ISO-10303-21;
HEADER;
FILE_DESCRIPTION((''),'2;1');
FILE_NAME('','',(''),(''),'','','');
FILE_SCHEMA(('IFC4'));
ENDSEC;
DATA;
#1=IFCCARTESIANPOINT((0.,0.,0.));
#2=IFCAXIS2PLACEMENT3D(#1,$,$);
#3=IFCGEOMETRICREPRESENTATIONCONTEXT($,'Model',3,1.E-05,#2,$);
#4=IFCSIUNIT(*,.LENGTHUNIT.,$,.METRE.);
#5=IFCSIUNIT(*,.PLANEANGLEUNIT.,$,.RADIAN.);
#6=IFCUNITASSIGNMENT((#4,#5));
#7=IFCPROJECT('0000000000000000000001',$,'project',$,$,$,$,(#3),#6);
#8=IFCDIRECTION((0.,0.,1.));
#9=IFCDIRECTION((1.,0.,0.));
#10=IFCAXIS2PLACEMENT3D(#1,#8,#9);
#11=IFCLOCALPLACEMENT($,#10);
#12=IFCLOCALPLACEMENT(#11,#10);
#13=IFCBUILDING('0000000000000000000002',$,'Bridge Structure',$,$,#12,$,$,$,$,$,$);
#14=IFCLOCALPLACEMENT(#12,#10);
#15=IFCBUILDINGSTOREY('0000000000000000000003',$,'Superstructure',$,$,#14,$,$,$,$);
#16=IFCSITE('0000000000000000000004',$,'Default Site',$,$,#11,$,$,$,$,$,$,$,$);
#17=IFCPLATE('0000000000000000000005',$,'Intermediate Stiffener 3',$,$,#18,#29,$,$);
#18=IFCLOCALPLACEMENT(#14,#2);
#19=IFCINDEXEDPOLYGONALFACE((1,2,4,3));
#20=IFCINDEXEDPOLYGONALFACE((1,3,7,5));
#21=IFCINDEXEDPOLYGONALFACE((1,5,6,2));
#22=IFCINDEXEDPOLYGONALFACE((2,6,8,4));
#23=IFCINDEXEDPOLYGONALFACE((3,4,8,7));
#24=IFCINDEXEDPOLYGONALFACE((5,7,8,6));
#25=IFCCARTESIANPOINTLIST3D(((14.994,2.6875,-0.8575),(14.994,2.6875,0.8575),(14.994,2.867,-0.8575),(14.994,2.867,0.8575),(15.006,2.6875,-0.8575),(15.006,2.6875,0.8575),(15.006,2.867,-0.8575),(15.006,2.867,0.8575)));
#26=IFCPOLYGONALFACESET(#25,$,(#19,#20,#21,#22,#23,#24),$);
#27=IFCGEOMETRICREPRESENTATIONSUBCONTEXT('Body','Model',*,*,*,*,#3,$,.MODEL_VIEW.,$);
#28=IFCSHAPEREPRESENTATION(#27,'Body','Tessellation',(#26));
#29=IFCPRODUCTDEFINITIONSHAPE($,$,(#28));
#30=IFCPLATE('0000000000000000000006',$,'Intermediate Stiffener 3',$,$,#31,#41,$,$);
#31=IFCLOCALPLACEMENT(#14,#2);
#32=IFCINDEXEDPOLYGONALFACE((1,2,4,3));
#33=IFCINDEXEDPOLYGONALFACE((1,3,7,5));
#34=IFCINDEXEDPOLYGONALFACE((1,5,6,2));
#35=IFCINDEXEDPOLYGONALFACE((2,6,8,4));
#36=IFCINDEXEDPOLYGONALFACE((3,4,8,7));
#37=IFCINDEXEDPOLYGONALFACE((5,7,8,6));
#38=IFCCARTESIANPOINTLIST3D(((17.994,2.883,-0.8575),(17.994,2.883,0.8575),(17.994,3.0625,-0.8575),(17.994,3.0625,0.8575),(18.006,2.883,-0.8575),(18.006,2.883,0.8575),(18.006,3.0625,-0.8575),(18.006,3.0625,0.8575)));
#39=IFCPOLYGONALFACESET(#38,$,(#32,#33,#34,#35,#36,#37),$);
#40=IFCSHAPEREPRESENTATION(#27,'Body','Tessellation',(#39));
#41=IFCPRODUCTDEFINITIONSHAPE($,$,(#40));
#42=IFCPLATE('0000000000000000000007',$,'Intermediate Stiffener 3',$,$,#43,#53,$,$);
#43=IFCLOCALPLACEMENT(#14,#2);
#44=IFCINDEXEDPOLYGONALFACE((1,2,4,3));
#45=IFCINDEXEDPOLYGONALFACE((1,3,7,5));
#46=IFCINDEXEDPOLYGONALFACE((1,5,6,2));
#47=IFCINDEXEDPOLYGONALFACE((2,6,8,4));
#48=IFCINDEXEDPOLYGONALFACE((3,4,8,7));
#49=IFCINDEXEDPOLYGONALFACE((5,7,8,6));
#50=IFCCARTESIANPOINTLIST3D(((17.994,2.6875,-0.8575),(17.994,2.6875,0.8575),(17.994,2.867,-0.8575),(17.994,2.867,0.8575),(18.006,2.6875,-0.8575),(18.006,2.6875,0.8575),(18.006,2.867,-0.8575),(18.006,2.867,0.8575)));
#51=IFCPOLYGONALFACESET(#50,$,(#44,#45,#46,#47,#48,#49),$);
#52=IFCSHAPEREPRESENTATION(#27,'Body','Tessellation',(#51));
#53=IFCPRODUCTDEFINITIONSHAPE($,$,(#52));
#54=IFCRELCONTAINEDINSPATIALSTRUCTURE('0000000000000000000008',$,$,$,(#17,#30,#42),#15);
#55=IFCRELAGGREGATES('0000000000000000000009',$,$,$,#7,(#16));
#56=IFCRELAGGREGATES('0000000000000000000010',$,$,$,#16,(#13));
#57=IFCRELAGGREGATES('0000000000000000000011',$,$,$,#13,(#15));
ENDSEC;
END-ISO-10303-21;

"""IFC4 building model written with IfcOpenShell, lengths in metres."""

from ifc_helpers import new_model, si_unit, frame, origin, origin_with_axes, origin_2d_with_axis, place, context, subcontext, project, spatial, rectangle, extrude, element, save


model = new_model("IFC4")

# Units and contexts
model_context = context("Model", 3, precision=1e-05, world=origin())
body_context = subcontext(model_context, "Body", "Model", "MODEL_VIEW")
ifc_project = project(units=[si_unit("LENGTHUNIT", "METRE"), si_unit("PLANEANGLEUNIT", "RADIAN")], contexts=[model_context])

# Site, building, storey
site_placement = place(None, origin_with_axes())
site = spatial("IfcSite", under=ifc_project, at=site_placement, Name="Default Site")
building_placement = place(site_placement, origin_with_axes())
building = spatial("IfcBuilding", under=site, at=building_placement, Name="Bridge Structure")
storey_placement = place(building_placement, origin_with_axes())
storey = spatial("IfcBuildingStorey", under=building, at=storey_placement, Name="Superstructure")

# Plates
for number, where, z_axis, x_axis, name in (
    (1, (15.0, 2.7772, -0.8575), (0.0, 0.0, 1.0), (1.0, 0.0, 0.0), "Intermediate Stiffener 3"),
    (2, (18.0, 2.9728, -0.8575), (0.0, 0.0, 1.0), (1.0, 0.0, 0.0), "Intermediate Stiffener 3"),
    (3, (18.0, 2.7772, -0.8575), (0.0, 0.0, 1.0), (1.0, 0.0, 0.0), "Intermediate Stiffener 3"),
):
    element("IfcPlate", number, at=place(storey_placement, frame(where, z_axis=z_axis, x_axis=x_axis)), inside=storey, Name=name, context=body_context, shape_type="SweptSolid", body=[
        extrude(rectangle(XDim=0.012, YDim=0.1795, at=origin_2d_with_axis()), origin_with_axes(), (0.0, 0.0, 1.0), 1.715),
    ])

save(model, "model.ifc")
